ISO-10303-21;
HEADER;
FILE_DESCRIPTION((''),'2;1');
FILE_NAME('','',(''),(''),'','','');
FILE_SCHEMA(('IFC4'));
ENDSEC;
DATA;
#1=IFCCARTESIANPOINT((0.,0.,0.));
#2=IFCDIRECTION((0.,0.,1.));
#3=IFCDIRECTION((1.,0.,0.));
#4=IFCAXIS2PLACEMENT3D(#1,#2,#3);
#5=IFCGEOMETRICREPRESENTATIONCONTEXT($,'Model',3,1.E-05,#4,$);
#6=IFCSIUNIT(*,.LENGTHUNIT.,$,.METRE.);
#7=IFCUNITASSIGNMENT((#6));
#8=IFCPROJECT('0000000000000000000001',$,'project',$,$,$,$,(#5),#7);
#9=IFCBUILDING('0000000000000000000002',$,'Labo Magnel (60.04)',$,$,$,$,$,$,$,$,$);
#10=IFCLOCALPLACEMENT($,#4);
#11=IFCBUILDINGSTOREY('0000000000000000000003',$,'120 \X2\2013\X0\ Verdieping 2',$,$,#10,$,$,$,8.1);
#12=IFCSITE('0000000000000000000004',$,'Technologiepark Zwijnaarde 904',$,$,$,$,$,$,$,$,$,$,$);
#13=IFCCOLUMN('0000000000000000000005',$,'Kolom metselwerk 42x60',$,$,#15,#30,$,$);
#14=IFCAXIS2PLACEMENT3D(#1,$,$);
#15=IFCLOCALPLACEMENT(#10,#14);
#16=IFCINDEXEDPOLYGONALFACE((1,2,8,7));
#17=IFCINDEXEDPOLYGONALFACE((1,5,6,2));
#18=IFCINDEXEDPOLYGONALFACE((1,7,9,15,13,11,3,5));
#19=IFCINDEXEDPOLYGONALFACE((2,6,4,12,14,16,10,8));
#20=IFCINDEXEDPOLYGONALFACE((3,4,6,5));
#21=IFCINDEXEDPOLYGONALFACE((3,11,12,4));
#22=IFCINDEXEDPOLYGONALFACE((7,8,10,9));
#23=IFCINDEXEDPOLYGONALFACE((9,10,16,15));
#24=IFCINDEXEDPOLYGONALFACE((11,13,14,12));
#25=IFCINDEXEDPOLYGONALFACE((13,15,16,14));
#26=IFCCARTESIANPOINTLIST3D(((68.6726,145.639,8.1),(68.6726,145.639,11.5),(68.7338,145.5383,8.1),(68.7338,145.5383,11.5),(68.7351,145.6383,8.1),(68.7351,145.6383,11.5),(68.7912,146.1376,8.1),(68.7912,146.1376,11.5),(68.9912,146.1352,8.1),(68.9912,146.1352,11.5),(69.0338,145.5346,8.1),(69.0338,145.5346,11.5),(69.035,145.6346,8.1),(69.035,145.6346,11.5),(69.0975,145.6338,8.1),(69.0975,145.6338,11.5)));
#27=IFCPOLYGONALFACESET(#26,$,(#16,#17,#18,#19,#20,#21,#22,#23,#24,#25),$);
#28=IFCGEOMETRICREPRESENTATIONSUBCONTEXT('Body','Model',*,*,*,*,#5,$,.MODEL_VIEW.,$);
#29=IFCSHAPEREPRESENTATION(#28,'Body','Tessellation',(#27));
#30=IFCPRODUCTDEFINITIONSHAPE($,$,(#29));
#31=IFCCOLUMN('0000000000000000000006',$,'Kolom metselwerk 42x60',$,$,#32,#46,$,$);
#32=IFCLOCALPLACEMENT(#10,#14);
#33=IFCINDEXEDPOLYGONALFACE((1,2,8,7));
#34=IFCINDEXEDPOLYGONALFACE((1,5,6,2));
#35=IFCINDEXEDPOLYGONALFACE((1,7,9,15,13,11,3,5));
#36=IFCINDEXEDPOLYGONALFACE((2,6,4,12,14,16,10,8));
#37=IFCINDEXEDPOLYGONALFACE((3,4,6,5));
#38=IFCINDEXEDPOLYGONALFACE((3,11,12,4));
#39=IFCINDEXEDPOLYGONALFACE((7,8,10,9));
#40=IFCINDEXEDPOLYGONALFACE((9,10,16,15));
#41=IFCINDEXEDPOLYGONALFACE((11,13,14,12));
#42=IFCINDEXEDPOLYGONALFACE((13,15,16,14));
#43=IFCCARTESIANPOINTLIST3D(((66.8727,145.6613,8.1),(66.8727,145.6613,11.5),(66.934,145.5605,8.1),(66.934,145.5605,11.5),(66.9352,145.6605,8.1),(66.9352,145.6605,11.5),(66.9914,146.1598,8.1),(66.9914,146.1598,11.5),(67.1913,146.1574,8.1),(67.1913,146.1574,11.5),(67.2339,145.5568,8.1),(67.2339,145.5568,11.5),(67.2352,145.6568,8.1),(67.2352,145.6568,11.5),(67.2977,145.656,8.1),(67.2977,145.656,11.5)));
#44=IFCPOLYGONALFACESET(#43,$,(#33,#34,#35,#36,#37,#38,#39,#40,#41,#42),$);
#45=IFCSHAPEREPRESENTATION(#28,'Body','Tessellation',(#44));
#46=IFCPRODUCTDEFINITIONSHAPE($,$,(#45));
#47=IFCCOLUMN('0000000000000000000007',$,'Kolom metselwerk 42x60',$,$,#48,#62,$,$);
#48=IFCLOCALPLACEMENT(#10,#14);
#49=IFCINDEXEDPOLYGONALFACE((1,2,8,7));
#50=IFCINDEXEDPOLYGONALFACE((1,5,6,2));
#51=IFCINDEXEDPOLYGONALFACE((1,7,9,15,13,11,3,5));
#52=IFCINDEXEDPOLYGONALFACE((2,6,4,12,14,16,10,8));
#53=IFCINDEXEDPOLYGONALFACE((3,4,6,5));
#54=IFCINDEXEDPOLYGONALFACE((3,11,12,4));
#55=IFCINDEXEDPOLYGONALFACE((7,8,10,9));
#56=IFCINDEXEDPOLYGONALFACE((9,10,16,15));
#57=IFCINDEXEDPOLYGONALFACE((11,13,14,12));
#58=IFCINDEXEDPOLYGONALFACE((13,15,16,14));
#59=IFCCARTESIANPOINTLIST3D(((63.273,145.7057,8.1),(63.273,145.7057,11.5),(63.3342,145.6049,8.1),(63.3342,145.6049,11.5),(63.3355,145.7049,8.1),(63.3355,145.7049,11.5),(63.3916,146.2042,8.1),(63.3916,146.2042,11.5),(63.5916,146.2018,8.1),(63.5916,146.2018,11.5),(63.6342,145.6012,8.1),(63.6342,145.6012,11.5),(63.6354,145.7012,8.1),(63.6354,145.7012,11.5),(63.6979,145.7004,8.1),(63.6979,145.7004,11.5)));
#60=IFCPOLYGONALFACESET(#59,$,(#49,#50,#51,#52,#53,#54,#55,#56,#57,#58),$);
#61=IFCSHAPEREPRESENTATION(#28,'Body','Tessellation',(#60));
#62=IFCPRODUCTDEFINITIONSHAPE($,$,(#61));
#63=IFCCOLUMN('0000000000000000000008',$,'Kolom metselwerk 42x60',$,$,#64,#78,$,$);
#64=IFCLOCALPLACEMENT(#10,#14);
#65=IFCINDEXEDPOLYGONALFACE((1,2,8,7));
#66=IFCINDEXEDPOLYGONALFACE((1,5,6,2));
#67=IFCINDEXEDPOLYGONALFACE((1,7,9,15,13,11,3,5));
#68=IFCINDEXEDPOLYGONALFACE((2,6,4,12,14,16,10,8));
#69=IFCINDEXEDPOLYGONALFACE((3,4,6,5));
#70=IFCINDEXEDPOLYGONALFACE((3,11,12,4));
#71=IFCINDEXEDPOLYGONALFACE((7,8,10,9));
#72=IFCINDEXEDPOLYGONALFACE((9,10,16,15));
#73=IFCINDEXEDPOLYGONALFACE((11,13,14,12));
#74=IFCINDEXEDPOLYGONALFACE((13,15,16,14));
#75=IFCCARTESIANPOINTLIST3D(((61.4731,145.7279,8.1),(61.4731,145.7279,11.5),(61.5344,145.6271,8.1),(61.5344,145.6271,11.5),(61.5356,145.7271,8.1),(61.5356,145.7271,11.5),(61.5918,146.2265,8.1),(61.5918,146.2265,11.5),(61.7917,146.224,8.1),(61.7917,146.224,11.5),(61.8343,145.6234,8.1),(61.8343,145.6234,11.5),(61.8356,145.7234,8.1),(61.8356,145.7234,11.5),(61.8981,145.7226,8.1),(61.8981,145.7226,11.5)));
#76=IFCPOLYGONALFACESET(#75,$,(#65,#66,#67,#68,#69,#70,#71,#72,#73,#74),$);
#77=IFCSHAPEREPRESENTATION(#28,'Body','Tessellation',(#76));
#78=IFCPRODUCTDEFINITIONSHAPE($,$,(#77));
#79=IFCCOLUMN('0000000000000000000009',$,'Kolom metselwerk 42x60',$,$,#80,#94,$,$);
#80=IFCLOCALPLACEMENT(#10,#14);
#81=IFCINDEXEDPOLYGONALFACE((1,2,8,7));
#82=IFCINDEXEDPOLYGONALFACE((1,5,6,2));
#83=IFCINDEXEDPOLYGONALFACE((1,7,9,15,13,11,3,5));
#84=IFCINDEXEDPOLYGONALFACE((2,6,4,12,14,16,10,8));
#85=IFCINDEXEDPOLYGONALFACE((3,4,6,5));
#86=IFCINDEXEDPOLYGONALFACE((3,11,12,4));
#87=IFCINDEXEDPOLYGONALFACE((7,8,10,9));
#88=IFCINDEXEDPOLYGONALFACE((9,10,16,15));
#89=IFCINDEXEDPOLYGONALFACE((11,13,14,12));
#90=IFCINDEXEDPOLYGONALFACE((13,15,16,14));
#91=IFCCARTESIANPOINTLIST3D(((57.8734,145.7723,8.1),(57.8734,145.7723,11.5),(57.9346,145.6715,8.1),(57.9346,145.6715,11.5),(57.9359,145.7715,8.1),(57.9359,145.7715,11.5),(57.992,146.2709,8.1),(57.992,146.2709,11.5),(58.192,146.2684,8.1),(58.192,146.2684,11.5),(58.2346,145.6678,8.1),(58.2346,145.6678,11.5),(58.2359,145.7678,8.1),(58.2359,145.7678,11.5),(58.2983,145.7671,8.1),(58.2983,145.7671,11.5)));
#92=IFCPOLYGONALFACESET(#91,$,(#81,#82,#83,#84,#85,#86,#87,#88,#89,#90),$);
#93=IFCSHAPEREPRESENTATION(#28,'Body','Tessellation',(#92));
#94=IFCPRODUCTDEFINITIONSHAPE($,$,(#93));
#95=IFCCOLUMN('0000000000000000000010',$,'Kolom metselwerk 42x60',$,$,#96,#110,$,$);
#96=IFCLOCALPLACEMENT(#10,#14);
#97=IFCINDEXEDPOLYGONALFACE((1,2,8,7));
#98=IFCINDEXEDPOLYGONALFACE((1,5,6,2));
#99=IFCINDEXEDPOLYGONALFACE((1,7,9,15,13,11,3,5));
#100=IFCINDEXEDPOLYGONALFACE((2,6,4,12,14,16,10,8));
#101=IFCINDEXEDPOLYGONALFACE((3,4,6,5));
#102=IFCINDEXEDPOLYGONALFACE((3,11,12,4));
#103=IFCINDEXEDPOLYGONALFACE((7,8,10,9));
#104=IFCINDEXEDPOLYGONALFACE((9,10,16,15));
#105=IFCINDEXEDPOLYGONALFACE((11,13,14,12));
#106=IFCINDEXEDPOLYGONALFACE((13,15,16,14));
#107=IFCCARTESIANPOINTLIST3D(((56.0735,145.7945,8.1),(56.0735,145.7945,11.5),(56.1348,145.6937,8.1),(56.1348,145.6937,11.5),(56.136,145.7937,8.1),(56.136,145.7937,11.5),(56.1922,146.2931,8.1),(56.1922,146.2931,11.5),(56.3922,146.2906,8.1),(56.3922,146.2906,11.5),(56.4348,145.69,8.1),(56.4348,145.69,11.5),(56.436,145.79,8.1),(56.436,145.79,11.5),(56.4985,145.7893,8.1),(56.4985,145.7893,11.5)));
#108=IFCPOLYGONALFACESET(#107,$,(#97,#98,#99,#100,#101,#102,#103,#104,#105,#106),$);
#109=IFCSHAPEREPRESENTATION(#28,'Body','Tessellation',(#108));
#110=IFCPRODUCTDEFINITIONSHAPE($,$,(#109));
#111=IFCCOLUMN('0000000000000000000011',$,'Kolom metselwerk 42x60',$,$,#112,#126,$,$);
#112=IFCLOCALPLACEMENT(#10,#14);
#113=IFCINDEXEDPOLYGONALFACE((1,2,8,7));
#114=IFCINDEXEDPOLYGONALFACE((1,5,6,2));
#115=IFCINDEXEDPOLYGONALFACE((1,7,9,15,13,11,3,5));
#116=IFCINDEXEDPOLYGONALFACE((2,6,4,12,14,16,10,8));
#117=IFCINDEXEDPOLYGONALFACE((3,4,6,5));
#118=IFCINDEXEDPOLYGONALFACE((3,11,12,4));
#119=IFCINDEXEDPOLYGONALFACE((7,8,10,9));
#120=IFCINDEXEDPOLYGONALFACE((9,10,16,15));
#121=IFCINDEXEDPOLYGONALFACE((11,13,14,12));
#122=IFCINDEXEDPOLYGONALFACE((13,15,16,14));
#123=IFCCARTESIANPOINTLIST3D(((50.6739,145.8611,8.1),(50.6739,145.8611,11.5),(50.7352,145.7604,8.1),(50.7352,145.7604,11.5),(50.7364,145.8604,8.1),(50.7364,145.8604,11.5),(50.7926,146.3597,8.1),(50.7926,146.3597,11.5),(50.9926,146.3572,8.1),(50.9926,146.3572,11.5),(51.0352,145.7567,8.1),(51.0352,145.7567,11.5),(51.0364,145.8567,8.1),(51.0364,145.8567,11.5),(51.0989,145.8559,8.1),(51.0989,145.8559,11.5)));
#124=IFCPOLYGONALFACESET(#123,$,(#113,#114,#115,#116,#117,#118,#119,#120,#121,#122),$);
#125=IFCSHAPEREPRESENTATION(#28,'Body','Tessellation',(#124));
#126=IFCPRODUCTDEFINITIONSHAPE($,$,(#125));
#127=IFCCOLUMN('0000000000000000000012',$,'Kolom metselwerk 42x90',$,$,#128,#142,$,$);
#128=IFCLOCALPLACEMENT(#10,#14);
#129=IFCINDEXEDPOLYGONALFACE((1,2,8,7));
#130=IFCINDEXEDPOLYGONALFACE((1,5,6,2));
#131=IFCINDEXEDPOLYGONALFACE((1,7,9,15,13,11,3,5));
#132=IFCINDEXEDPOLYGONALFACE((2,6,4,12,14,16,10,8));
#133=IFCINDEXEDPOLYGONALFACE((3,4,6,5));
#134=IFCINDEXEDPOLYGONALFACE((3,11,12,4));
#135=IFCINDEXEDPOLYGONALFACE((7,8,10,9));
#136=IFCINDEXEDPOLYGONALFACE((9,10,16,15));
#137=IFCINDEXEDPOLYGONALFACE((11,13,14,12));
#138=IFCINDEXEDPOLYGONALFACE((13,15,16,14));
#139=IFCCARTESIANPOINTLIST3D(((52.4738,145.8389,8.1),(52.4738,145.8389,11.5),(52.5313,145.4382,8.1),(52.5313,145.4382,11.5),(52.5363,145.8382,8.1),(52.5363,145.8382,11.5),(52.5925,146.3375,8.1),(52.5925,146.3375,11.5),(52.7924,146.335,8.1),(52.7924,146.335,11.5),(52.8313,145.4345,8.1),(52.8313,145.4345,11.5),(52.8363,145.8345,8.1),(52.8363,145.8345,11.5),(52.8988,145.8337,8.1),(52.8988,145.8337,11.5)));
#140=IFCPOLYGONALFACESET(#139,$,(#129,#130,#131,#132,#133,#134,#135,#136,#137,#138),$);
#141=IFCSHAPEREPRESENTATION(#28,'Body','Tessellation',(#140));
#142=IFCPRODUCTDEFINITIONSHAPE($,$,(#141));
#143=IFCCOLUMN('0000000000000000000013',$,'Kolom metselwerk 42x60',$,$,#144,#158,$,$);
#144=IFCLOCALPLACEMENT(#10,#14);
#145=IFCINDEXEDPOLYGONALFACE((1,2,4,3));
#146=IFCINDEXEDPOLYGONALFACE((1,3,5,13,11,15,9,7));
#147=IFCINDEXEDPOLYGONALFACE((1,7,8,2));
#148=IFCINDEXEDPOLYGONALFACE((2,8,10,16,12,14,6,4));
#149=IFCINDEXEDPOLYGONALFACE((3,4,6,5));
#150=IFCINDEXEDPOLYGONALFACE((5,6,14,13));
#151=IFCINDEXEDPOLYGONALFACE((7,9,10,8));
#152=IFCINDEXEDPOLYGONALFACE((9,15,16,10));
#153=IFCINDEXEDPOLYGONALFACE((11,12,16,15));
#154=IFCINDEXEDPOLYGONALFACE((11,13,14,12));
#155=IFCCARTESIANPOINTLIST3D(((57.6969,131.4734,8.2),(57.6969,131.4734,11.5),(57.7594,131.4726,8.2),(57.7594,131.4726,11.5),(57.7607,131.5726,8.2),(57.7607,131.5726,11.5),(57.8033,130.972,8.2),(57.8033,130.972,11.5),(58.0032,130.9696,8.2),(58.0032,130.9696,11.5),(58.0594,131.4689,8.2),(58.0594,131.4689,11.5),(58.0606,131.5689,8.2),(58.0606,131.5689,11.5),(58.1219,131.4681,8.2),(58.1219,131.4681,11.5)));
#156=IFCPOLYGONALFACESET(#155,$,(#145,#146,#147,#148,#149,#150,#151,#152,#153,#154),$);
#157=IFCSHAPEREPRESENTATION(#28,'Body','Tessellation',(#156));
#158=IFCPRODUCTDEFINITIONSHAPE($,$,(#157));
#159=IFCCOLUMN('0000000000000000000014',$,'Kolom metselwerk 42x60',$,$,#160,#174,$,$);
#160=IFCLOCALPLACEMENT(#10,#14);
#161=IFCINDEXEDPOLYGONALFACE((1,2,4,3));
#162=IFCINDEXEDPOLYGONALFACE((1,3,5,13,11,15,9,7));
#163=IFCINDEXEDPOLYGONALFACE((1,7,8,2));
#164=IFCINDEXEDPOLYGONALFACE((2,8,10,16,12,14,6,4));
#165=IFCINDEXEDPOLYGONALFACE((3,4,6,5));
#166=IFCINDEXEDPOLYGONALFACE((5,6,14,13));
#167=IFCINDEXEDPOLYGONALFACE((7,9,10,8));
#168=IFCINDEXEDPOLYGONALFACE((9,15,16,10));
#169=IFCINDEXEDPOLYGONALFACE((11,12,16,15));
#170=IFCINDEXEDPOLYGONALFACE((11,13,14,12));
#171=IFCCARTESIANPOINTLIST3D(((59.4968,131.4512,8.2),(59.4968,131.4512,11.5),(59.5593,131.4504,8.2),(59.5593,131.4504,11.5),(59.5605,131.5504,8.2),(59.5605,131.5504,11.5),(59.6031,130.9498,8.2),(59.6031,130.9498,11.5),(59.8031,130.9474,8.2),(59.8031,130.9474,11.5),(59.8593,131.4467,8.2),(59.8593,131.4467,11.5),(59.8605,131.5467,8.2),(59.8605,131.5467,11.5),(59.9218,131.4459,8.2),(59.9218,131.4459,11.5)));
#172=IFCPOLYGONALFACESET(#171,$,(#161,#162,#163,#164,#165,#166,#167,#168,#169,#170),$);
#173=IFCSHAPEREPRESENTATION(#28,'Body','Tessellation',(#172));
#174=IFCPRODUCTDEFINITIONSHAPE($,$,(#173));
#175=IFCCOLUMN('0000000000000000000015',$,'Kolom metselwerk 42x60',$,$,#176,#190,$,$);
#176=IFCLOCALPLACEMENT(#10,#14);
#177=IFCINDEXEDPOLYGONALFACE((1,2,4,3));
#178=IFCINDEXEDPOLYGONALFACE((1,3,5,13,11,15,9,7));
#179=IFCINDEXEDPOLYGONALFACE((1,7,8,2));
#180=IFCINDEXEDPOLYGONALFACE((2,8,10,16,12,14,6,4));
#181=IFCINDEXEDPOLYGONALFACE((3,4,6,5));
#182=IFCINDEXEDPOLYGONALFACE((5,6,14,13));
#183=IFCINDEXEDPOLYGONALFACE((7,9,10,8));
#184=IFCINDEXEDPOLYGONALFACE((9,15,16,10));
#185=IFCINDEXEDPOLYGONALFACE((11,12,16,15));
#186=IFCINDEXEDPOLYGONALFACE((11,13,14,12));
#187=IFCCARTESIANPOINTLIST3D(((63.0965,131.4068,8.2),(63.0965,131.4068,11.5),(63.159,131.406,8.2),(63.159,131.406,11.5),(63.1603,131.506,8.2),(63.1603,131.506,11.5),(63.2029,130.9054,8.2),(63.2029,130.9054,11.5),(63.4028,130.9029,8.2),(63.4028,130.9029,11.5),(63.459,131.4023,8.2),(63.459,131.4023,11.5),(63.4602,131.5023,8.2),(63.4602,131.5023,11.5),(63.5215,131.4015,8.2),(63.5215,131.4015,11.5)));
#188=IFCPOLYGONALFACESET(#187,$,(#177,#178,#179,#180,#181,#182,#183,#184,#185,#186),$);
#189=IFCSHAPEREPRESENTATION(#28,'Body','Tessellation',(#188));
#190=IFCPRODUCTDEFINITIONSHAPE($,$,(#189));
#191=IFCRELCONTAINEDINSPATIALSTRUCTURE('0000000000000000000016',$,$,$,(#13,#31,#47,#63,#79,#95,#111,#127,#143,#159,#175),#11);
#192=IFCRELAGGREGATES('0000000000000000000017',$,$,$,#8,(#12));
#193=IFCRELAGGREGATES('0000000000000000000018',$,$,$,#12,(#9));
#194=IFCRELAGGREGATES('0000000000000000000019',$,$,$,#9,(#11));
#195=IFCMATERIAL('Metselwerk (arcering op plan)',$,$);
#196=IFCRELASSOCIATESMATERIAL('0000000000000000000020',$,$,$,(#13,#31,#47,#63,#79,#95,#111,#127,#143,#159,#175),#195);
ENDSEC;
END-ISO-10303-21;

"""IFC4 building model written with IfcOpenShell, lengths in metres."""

from ifc_helpers import new_model, si_unit, frame, origin, origin_with_axes, place, context, subcontext, project, spatial, polyline, outline, extrude, material, element, save


model = new_model("IFC4")

# Units and contexts
model_context = context("Model", 3, precision=1e-05, world=origin_with_axes())
body_context = subcontext(model_context, "Body", "Model", "MODEL_VIEW")
ifc_project = project(units=[si_unit("LENGTHUNIT", "METRE")], contexts=[model_context])

# Site, building, storey
site = spatial("IfcSite", under=ifc_project, Name="Technologiepark Zwijnaarde 904")
building = spatial("IfcBuilding", under=site, Name="Labo Magnel (60.04)")
storey_placement = place(None, origin_with_axes())
storey = spatial("IfcBuildingStorey", under=building, at=storey_placement, Name="120 – Verdieping 2", Elevation=8.1)

# Columns
ifc_material_1 = material(Name="Metselwerk (arcering op plan)")
column_1_placement = place(storey_placement, frame((0.0, 0.0, 8.1), z_axis=(0.0, 0.0, 1.0), x_axis=(1.0, 0.0, 0.0)))
element("IfcColumn", 1, at=column_1_placement, inside=storey, material=ifc_material_1, Name="Kolom metselwerk 42x60", context=body_context, shape_type="SweptSolid", body=[
    extrude(outline(polyline([(68.9912, 146.1352), (68.7912, 146.1376), (68.6726, 145.639), (68.7351, 145.6383), (68.7338, 145.5383), (69.0338, 145.5346), (69.035, 145.6346), (69.0975, 145.6338), (68.9912, 146.1352)])), origin(), (0.0, 0.0, 1.0), 3.4),
])
column_2_placement = place(storey_placement, frame((0.0, 0.0, 8.1), z_axis=(0.0, 0.0, 1.0), x_axis=(1.0, 0.0, 0.0)))
element("IfcColumn", 2, at=column_2_placement, inside=storey, material=ifc_material_1, Name="Kolom metselwerk 42x60", context=body_context, shape_type="SweptSolid", body=[
    extrude(outline(polyline([(67.1913, 146.1574), (66.9914, 146.1598), (66.8727, 145.6613), (66.9352, 145.6605), (66.934, 145.5605), (67.2339, 145.5568), (67.2352, 145.6568), (67.2977, 145.656), (67.1913, 146.1574)])), origin(), (0.0, 0.0, 1.0), 3.4),
])
column_3_placement = place(storey_placement, frame((0.0, 0.0, 8.1), z_axis=(0.0, 0.0, 1.0), x_axis=(1.0, 0.0, 0.0)))
element("IfcColumn", 3, at=column_3_placement, inside=storey, material=ifc_material_1, Name="Kolom metselwerk 42x60", context=body_context, shape_type="SweptSolid", body=[
    extrude(outline(polyline([(63.5916, 146.2018), (63.3916, 146.2042), (63.273, 145.7057), (63.3355, 145.7049), (63.3342, 145.6049), (63.6342, 145.6012), (63.6354, 145.7012), (63.6979, 145.7004), (63.5916, 146.2018)])), origin(), (0.0, 0.0, 1.0), 3.4),
])
column_4_placement = place(storey_placement, frame((0.0, 0.0, 8.1), z_axis=(0.0, 0.0, 1.0), x_axis=(1.0, 0.0, 0.0)))
element("IfcColumn", 4, at=column_4_placement, inside=storey, material=ifc_material_1, Name="Kolom metselwerk 42x60", context=body_context, shape_type="SweptSolid", body=[
    extrude(outline(polyline([(61.7917, 146.224), (61.5918, 146.2265), (61.4731, 145.7279), (61.5356, 145.7271), (61.5344, 145.6271), (61.8343, 145.6234), (61.8356, 145.7234), (61.8981, 145.7226), (61.7917, 146.224)])), origin(), (0.0, 0.0, 1.0), 3.4),
])
column_5_placement = place(storey_placement, frame((0.0, 0.0, 8.1), z_axis=(0.0, 0.0, 1.0), x_axis=(1.0, 0.0, 0.0)))
element("IfcColumn", 5, at=column_5_placement, inside=storey, material=ifc_material_1, Name="Kolom metselwerk 42x60", context=body_context, shape_type="SweptSolid", body=[
    extrude(outline(polyline([(58.192, 146.2684), (57.992, 146.2709), (57.8734, 145.7723), (57.9359, 145.7715), (57.9346, 145.6715), (58.2346, 145.6678), (58.2359, 145.7678), (58.2983, 145.7671), (58.192, 146.2684)])), origin(), (0.0, 0.0, 1.0), 3.4),
])
column_6_placement = place(storey_placement, frame((0.0, 0.0, 8.1), z_axis=(0.0, 0.0, 1.0), x_axis=(1.0, 0.0, 0.0)))
element("IfcColumn", 6, at=column_6_placement, inside=storey, material=ifc_material_1, Name="Kolom metselwerk 42x60", context=body_context, shape_type="SweptSolid", body=[
    extrude(outline(polyline([(56.3922, 146.2906), (56.1922, 146.2931), (56.0735, 145.7945), (56.136, 145.7937), (56.1348, 145.6937), (56.4348, 145.69), (56.436, 145.79), (56.4985, 145.7893), (56.3922, 146.2906)])), origin(), (0.0, 0.0, 1.0), 3.4),
])
column_7_placement = place(storey_placement, frame((0.0, 0.0, 8.1), z_axis=(0.0, 0.0, 1.0), x_axis=(1.0, 0.0, 0.0)))
element("IfcColumn", 7, at=column_7_placement, inside=storey, material=ifc_material_1, Name="Kolom metselwerk 42x60", context=body_context, shape_type="SweptSolid", body=[
    extrude(outline(polyline([(50.9926, 146.3572), (50.7926, 146.3597), (50.6739, 145.8611), (50.7364, 145.8604), (50.7352, 145.7604), (51.0352, 145.7567), (51.0364, 145.8567), (51.0989, 145.8559), (50.9926, 146.3572)])), origin(), (0.0, 0.0, 1.0), 3.4),
])
column_8_placement = place(storey_placement, frame((0.0, 0.0, 8.1), z_axis=(0.0, 0.0, 1.0), x_axis=(1.0, 0.0, 0.0)))
element("IfcColumn", 8, at=column_8_placement, inside=storey, material=ifc_material_1, Name="Kolom metselwerk 42x90", context=body_context, shape_type="SweptSolid", body=[
    extrude(outline(polyline([(52.7924, 146.335), (52.5925, 146.3375), (52.4738, 145.8389), (52.5363, 145.8382), (52.5313, 145.4382), (52.8313, 145.4345), (52.8363, 145.8345), (52.8988, 145.8337), (52.7924, 146.335)])), origin(), (0.0, 0.0, 1.0), 3.4),
])
column_9_placement = place(storey_placement, frame((0.0, 0.0, 8.2), z_axis=(0.0, 0.0, 1.0), x_axis=(1.0, 0.0, 0.0)))
element("IfcColumn", 9, at=column_9_placement, inside=storey, material=ifc_material_1, Name="Kolom metselwerk 42x60", context=body_context, shape_type="SweptSolid", body=[
    extrude(outline(polyline([(58.1219, 131.4681), (58.0594, 131.4689), (58.0606, 131.5689), (57.7607, 131.5726), (57.7594, 131.4726), (57.6969, 131.4734), (57.8033, 130.972), (58.0032, 130.9696), (58.1219, 131.4681)])), origin(), (0.0, 0.0, 1.0), 3.3),
])
column_10_placement = place(storey_placement, frame((0.0, 0.0, 8.2), z_axis=(0.0, 0.0, 1.0), x_axis=(1.0, 0.0, 0.0)))
element("IfcColumn", 10, at=column_10_placement, inside=storey, material=ifc_material_1, Name="Kolom metselwerk 42x60", context=body_context, shape_type="SweptSolid", body=[
    extrude(outline(polyline([(59.9218, 131.4459), (59.8593, 131.4467), (59.8605, 131.5467), (59.5605, 131.5504), (59.5593, 131.4504), (59.4968, 131.4512), (59.6031, 130.9498), (59.8031, 130.9474), (59.9218, 131.4459)])), origin(), (0.0, 0.0, 1.0), 3.3),
])
column_11_placement = place(storey_placement, frame((0.0, 0.0, 8.2), z_axis=(0.0, 0.0, 1.0), x_axis=(1.0, 0.0, 0.0)))
element("IfcColumn", 11, at=column_11_placement, inside=storey, material=ifc_material_1, Name="Kolom metselwerk 42x60", context=body_context, shape_type="SweptSolid", body=[
    extrude(outline(polyline([(63.5215, 131.4015), (63.459, 131.4023), (63.4602, 131.5023), (63.1603, 131.506), (63.159, 131.406), (63.0965, 131.4068), (63.2029, 130.9054), (63.4028, 130.9029), (63.5215, 131.4015)])), origin(), (0.0, 0.0, 1.0), 3.3),
])

save(model, "model.ifc")
